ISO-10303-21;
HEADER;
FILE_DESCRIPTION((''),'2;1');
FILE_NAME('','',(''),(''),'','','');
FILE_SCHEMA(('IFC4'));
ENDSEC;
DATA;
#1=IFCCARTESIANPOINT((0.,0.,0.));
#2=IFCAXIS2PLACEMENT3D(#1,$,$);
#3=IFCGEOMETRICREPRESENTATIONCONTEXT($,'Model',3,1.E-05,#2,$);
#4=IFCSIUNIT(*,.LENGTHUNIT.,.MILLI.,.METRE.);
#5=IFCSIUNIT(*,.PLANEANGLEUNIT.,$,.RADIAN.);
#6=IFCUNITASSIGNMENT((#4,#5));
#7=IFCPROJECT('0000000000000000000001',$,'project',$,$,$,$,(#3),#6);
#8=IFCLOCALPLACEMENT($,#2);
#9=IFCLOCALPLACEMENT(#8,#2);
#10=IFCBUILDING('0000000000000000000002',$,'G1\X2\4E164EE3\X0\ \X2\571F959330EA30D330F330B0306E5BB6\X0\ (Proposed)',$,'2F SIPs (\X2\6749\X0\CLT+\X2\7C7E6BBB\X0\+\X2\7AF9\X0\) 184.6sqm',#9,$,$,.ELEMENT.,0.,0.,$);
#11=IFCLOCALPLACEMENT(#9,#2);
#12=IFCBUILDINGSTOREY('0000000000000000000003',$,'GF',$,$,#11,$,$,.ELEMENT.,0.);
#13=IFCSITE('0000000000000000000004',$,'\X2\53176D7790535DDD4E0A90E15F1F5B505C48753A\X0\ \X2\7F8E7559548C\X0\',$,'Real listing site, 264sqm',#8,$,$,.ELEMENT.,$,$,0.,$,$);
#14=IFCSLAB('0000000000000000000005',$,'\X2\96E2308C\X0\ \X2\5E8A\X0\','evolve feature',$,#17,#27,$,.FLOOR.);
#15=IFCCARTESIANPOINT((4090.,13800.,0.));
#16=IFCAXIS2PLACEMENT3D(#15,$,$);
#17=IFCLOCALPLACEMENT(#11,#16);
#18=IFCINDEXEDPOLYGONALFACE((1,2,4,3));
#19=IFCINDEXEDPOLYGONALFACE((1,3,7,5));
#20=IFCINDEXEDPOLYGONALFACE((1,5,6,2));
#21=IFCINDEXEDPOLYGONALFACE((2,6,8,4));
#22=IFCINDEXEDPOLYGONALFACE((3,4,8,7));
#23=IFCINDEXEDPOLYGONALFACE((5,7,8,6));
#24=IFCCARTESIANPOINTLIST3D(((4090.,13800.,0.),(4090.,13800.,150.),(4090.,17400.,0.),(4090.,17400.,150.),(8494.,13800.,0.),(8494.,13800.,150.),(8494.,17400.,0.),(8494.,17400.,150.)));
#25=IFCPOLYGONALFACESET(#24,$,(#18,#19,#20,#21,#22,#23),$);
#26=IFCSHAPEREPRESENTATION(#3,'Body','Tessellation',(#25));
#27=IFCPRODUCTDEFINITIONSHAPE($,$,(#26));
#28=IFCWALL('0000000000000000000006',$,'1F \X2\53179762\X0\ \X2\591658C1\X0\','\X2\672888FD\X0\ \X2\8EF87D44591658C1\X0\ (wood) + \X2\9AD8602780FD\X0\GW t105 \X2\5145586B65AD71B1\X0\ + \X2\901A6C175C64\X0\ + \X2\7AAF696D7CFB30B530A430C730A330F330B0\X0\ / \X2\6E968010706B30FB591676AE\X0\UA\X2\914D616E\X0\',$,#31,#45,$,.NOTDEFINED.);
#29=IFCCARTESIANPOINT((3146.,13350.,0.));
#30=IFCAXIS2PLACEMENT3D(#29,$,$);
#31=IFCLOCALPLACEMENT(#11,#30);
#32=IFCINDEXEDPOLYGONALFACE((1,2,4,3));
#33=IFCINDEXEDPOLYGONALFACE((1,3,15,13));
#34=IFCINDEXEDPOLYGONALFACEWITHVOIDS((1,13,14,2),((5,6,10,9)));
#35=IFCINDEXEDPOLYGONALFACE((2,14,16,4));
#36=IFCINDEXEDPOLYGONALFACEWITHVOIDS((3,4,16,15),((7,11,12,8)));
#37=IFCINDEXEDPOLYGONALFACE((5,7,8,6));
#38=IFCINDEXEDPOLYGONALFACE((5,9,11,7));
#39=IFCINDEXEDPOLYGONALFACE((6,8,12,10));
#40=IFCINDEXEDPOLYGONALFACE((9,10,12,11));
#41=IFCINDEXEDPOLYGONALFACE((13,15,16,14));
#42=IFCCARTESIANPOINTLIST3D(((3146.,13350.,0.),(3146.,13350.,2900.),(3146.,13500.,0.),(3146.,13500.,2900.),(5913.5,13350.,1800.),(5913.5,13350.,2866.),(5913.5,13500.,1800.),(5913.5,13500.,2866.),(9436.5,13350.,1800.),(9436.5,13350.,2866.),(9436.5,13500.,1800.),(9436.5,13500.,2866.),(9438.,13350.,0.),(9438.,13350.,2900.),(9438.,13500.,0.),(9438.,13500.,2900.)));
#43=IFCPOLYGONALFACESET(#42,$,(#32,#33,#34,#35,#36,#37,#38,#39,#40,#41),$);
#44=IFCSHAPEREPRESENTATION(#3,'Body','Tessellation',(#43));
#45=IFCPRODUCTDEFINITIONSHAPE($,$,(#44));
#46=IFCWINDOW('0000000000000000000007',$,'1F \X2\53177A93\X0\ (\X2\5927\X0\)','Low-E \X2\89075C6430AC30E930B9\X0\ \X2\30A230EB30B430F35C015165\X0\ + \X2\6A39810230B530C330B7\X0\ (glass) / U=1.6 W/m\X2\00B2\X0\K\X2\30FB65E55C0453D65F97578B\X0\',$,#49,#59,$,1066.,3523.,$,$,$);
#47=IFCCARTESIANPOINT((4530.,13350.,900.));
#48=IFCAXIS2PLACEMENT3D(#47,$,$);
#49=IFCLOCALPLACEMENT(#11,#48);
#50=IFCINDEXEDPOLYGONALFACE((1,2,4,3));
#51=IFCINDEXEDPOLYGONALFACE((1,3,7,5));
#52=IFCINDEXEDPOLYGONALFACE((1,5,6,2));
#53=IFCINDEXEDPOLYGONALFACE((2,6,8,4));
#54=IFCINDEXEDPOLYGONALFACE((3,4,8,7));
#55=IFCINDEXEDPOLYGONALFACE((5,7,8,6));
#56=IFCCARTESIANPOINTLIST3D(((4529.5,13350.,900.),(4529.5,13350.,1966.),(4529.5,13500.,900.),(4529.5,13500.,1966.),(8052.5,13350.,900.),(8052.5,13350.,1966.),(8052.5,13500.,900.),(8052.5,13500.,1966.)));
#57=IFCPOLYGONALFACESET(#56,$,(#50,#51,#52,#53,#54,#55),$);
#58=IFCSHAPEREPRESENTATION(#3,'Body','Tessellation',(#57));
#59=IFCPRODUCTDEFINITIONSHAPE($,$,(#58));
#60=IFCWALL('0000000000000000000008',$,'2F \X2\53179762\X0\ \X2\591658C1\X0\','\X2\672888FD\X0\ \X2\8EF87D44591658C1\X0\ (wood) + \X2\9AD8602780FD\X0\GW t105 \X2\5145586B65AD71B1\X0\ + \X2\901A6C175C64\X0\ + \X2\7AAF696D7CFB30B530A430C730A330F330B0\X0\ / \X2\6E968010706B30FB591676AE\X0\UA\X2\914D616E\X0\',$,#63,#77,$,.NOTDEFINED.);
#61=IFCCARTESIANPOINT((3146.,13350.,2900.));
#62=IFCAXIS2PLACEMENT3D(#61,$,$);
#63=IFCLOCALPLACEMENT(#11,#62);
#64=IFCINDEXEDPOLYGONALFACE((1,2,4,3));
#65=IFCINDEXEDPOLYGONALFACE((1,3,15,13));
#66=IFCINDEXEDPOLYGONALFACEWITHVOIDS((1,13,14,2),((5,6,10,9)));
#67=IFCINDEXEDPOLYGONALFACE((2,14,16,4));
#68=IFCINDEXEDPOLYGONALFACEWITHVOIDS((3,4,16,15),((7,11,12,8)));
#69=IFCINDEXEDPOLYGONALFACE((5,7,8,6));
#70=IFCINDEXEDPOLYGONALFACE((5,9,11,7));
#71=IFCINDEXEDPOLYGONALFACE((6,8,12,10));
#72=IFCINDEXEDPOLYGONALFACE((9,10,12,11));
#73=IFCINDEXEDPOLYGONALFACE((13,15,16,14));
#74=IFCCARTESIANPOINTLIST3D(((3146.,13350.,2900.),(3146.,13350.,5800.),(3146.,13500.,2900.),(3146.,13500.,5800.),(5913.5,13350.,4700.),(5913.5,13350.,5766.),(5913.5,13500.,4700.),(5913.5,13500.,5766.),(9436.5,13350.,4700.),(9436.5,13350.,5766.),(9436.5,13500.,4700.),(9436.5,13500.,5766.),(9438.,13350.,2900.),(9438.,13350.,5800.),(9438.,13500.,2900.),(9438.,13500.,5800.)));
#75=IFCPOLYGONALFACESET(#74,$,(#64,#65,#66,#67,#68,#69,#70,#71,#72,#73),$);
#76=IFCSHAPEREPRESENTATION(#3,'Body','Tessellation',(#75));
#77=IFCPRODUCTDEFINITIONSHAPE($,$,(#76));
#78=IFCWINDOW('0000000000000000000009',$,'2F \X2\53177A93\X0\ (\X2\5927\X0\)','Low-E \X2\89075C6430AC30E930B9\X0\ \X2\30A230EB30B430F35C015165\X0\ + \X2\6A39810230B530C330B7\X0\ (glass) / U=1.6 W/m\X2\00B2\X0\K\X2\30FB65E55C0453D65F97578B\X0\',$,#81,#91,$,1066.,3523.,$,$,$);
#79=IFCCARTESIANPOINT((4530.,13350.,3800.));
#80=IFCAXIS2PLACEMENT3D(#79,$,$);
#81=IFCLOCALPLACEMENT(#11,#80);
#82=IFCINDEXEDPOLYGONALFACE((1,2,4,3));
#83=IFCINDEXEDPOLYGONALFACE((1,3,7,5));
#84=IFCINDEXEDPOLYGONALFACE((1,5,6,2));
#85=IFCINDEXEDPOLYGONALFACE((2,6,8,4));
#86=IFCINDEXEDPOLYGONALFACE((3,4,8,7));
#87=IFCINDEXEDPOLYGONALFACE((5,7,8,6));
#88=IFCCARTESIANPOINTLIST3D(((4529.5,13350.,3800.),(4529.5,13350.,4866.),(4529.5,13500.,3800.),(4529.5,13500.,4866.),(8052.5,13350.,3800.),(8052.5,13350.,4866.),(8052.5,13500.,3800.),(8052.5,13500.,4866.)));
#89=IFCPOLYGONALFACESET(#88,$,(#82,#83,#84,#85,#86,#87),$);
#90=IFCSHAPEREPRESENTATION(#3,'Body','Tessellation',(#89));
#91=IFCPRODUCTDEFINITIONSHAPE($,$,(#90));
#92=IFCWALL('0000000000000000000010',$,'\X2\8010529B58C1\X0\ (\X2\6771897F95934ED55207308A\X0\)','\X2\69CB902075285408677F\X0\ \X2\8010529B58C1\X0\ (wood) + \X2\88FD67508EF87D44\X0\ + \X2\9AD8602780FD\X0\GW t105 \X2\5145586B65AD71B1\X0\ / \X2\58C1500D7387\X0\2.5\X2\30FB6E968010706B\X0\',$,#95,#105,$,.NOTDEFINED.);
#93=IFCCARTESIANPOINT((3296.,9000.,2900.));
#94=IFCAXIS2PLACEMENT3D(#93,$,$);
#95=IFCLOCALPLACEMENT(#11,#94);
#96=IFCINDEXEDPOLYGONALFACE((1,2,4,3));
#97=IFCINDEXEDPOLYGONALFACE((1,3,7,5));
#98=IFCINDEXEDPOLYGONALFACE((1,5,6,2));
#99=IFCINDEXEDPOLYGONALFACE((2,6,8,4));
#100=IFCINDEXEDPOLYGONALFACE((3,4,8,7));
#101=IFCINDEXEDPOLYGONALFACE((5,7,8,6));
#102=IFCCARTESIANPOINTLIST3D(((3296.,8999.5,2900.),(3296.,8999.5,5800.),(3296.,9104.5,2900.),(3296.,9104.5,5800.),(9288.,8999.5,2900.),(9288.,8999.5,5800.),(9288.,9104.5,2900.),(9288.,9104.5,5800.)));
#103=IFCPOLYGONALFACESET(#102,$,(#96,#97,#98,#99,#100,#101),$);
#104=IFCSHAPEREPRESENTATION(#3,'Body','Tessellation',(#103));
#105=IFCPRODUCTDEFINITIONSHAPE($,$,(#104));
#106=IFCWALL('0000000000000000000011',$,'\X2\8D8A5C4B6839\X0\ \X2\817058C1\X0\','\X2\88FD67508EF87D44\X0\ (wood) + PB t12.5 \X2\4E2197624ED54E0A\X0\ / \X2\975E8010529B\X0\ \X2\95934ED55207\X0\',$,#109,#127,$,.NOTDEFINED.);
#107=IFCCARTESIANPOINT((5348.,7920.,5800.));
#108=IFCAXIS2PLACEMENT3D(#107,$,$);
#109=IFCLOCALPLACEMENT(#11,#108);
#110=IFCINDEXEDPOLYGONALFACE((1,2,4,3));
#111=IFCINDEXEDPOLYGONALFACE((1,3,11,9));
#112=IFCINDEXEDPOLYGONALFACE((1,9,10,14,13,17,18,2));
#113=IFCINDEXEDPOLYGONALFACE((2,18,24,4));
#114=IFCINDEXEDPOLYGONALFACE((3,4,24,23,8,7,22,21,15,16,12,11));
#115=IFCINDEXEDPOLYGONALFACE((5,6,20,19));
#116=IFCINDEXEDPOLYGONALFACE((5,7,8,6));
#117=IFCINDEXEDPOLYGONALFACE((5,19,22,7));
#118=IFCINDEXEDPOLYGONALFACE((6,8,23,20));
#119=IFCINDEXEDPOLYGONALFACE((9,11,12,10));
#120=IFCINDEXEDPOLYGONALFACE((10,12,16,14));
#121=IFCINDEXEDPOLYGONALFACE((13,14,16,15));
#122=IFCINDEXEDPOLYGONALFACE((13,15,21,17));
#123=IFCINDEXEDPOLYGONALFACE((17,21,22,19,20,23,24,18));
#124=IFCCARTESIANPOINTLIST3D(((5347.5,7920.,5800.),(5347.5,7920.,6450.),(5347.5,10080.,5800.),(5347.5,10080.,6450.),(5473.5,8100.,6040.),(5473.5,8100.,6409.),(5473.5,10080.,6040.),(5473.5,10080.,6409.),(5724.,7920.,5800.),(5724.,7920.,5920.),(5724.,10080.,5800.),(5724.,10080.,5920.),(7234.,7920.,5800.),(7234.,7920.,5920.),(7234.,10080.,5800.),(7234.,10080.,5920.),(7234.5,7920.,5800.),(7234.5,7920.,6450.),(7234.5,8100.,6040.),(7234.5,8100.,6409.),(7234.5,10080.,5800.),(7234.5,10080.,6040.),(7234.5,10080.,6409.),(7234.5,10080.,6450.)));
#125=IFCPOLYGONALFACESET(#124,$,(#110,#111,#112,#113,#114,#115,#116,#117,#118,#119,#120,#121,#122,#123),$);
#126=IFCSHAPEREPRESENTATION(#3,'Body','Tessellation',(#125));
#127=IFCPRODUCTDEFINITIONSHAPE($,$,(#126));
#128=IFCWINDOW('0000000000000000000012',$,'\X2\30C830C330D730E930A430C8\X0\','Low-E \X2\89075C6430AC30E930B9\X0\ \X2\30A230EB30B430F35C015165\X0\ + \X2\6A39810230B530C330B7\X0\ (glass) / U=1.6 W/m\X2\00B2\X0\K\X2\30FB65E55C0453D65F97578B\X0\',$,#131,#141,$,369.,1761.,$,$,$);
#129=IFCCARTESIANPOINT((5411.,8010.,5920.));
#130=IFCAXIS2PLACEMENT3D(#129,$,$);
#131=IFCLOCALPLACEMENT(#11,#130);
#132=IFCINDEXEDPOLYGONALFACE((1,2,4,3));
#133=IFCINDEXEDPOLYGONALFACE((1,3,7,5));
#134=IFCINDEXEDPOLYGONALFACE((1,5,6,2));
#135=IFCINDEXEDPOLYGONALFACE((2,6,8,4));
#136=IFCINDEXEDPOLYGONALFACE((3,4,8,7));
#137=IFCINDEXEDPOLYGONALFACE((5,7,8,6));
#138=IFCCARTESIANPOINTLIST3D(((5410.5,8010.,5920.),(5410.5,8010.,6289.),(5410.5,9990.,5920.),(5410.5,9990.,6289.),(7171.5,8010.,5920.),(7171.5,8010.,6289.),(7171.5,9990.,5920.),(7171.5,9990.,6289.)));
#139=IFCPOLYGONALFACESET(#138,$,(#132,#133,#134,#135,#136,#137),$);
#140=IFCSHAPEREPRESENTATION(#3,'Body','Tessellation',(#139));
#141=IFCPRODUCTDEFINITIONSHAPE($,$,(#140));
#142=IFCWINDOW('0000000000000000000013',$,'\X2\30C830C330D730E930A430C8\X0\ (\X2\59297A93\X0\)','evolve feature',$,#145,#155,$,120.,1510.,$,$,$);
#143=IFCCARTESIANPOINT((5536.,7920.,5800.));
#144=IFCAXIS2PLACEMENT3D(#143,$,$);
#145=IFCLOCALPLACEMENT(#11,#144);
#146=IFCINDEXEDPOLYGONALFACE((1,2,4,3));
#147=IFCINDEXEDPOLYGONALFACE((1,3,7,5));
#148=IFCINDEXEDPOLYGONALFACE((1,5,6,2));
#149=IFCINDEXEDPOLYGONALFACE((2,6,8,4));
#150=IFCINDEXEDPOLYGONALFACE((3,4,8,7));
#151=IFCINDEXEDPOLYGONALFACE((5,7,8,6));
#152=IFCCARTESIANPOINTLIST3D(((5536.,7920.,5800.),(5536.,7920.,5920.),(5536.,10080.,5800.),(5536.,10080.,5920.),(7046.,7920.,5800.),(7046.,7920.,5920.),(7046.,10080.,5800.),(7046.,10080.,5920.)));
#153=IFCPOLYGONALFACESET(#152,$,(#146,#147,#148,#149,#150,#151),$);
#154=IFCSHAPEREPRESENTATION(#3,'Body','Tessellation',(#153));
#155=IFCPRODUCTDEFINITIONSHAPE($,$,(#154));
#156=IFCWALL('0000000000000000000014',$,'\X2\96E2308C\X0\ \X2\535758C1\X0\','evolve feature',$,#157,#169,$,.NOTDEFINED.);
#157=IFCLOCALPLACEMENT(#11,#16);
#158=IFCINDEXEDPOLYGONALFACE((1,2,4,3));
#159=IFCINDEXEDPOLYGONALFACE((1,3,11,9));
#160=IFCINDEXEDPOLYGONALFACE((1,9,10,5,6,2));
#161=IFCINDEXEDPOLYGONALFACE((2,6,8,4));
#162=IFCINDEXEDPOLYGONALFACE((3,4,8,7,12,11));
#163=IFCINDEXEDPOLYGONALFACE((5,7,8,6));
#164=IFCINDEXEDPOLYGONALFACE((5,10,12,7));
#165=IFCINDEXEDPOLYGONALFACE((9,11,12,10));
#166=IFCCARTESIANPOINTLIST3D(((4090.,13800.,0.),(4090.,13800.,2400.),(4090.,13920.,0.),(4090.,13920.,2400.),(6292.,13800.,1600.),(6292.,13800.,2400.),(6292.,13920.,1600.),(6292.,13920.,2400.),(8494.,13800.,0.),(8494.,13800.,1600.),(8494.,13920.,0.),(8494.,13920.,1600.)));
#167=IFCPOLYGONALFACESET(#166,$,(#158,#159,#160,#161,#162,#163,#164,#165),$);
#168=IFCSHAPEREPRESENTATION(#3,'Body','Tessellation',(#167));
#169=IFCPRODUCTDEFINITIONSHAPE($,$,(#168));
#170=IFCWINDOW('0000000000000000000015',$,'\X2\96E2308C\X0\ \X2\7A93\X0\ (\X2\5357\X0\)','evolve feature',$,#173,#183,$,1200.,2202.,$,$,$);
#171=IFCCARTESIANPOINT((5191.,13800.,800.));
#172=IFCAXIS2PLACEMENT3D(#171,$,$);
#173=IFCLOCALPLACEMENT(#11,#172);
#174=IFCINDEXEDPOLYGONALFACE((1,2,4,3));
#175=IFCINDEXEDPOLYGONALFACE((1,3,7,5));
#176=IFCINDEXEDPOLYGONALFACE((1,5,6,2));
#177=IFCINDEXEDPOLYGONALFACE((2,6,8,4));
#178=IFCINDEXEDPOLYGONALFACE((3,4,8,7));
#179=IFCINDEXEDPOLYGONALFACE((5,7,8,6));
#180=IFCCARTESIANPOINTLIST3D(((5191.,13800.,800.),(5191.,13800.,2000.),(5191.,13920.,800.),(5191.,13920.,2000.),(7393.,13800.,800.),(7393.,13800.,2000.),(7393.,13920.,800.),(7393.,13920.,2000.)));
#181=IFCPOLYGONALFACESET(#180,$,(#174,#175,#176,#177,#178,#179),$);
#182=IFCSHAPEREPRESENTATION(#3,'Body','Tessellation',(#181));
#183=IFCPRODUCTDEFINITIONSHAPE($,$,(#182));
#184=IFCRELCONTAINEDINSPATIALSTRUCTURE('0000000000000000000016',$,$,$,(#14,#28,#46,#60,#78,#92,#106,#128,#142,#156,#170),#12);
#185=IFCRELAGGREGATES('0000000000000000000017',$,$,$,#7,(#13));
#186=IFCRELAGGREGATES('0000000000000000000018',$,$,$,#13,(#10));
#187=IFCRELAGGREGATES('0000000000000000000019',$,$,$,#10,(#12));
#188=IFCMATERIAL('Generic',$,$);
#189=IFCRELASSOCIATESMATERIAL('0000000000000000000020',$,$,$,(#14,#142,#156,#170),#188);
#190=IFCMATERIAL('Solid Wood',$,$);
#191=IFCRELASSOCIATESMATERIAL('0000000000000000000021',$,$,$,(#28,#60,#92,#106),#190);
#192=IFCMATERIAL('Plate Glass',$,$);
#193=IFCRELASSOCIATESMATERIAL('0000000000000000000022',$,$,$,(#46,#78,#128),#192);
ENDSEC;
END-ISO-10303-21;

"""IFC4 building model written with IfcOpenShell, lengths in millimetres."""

from ifc_helpers import new_model, si_unit, frame, frame_2d, origin, place, context, project, spatial, rectangle, extrude, material, element, fill, save


model = new_model("IFC4")

# Units and contexts
model_context = context("Model", 3, precision=1e-05, world=origin())
ifc_project = project(units=[si_unit("LENGTHUNIT", "METRE", prefix="MILLI"), si_unit("PLANEANGLEUNIT", "RADIAN")], contexts=[model_context])

# Site, building, storey
site_placement = place(None, origin())
site = spatial("IfcSite", under=ifc_project, at=site_placement, Name="北海道川上郡弟子屈町 美留和", ObjectType="Real listing site, 264sqm", CompositionType="ELEMENT", RefElevation=0.0)
building_placement = place(site_placement, origin())
building = spatial("IfcBuilding", under=site, at=building_placement, Name="G1世代 土間リビングの家 (Proposed)", ObjectType="2F SIPs (杉CLT+籾殻+竹) 184.6sqm", CompositionType="ELEMENT", ElevationOfRefHeight=0.0, ElevationOfTerrain=0.0)
storey_placement = place(building_placement, origin())
storey = spatial("IfcBuildingStorey", under=building, at=storey_placement, Name="GF", CompositionType="ELEMENT", Elevation=0.0)

# Slab
ifc_material_1 = material(Name="Generic")
slab_placement = place(storey_placement, frame((4090.0, 13800.0, 0.0)))
element("IfcSlab", 1, at=slab_placement, inside=storey, material=ifc_material_1, Name="離れ 床", Description="evolve feature", PredefinedType="FLOOR", context=model_context, shape_type="SweptSolid", body=[
    extrude(rectangle(XDim=4404.0, YDim=3600.0, at=frame_2d((2202.0, 1800.0))), frame((4090.0, 13800.0, 0.0)), (0.0, 0.0, 1.0), 150.0),
])

# Wall, opening, window
ifc_material_2 = material(Name="Solid Wood")
wall_1_placement = place(storey_placement, frame((3146.0, 13350.0, 0.0)))
wall_1 = element("IfcWall", 2, at=wall_1_placement, inside=storey, material=ifc_material_2, Name="1F 北面 外壁", Description="木製 軸組外壁 (wood) + 高性能GW t105 充填断熱 + 通気層 + 窯業系サイディング / 準耐火・外皮UA配慮", PredefinedType="NOTDEFINED", context=model_context, shape_type="SweptSolid", body=[
    extrude(rectangle(XDim=6292.0, YDim=150.0, at=frame_2d((3146.0, 75.0))), frame((3146.0, 13350.0, 0.0)), (0.0, 0.0, 1.0), 2900.0),
])
opening_1_placement = place(storey_placement, frame((4530.0, 13350.0, 900.0)))
opening_1 = element("IfcOpeningElement", 3, at=opening_1_placement, cuts=wall_1, PredefinedType="NOTDEFINED", context=model_context, shape_type="SweptSolid", body=[
    extrude(rectangle(XDim=3523.0, YDim=150.0, at=frame_2d((1761.0, 75.0))), frame((4530.0, 13350.0, 900.0)), (0.0, 0.0, 1.0), 1066.0),
])
ifc_material_3 = material(Name="Plate Glass")
window_1_placement = place(storey_placement, frame((4530.0, 13350.0, 900.0)))
window_1 = element("IfcWindow", 4, at=window_1_placement, inside=storey, material=ifc_material_3, Name="1F 北窓 (大)", Description="Low-E 複層ガラス アルゴン封入 + 樹脂サッシ (glass) / U=1.6 W/m²K・日射取得型", OverallHeight=1066.0, OverallWidth=3523.0, context=model_context, shape_type="SweptSolid", body=[
    extrude(rectangle(XDim=3523.0, YDim=150.0, at=frame_2d((1761.0, 75.0))), frame((4530.0, 13350.0, 900.0)), (0.0, 0.0, 1.0), 1066.0),
])
fill(opening_1, window_1)

# Wall, opening, window
wall_2_placement = place(storey_placement, frame((3146.0, 13350.0, 2900.0)))
wall_2 = element("IfcWall", 5, at=wall_2_placement, inside=storey, material=ifc_material_2, Name="2F 北面 外壁", Description="木製 軸組外壁 (wood) + 高性能GW t105 充填断熱 + 通気層 + 窯業系サイディング / 準耐火・外皮UA配慮", PredefinedType="NOTDEFINED", context=model_context, shape_type="SweptSolid", body=[
    extrude(rectangle(XDim=6292.0, YDim=150.0, at=frame_2d((3146.0, 75.0))), frame((3146.0, 13350.0, 2900.0)), (0.0, 0.0, 1.0), 2900.0),
])
opening_2_placement = place(storey_placement, frame((4530.0, 13350.0, 3800.0)))
opening_2 = element("IfcOpeningElement", 6, at=opening_2_placement, cuts=wall_2, PredefinedType="NOTDEFINED", context=model_context, shape_type="SweptSolid", body=[
    extrude(rectangle(XDim=3523.0, YDim=150.0, at=frame_2d((1761.0, 75.0))), frame((4530.0, 13350.0, 3800.0)), (0.0, 0.0, 1.0), 1066.0),
])
window_2_placement = place(storey_placement, frame((4530.0, 13350.0, 3800.0)))
window_2 = element("IfcWindow", 7, at=window_2_placement, inside=storey, material=ifc_material_3, Name="2F 北窓 (大)", Description="Low-E 複層ガラス アルゴン封入 + 樹脂サッシ (glass) / U=1.6 W/m²K・日射取得型", OverallHeight=1066.0, OverallWidth=3523.0, context=model_context, shape_type="SweptSolid", body=[
    extrude(rectangle(XDim=3523.0, YDim=150.0, at=frame_2d((1761.0, 75.0))), frame((4530.0, 13350.0, 3800.0)), (0.0, 0.0, 1.0), 1066.0),
])
fill(opening_2, window_2)

# Wall
wall_3_placement = place(storey_placement, frame((3296.0, 9000.0, 2900.0)))
element("IfcWall", 8, at=wall_3_placement, inside=storey, material=ifc_material_2, Name="耐力壁 (東西間仕切り)", Description="構造用合板 耐力壁 (wood) + 製材軸組 + 高性能GW t105 充填断熱 / 壁倍率2.5・準耐火", PredefinedType="NOTDEFINED", context=model_context, shape_type="SweptSolid", body=[
    extrude(rectangle(XDim=5992.0, YDim=105.0, at=frame_2d((2996.0, 52.0))), frame((3296.0, 9000.0, 2900.0)), (0.0, 0.0, 1.0), 2900.0),
])

# Wall, openings, windows
wall_4_placement = place(storey_placement, frame((5348.0, 7920.0, 5800.0)))
wall_4 = element("IfcWall", 9, at=wall_4_placement, inside=storey, material=ifc_material_2, Name="越屋根 腰壁", Description="製材軸組 (wood) + PB t12.5 両面仕上 / 非耐力 間仕切", PredefinedType="NOTDEFINED", context=model_context, shape_type="SweptSolid", body=[
    extrude(rectangle(XDim=1887.0, YDim=2160.0, at=frame_2d((943.0, 1080.0))), frame((5348.0, 7920.0, 5800.0)), (0.0, 0.0, 1.0), 650.0),
])
opening_3_placement = place(storey_placement, frame((5411.0, 8010.0, 5920.0)))
opening_3 = element("IfcOpeningElement", 10, at=opening_3_placement, cuts=wall_4, PredefinedType="NOTDEFINED", context=model_context, shape_type="SweptSolid", body=[
    extrude(rectangle(XDim=1761.0, YDim=1980.0, at=frame_2d((880.0, 990.0))), frame((5411.0, 8010.0, 5920.0)), (0.0, 0.0, 1.0), 369.0),
])
opening_4_placement = place(storey_placement, frame((5536.0, 7920.0, 5800.0)))
opening_4 = element("IfcOpeningElement", 11, at=opening_4_placement, cuts=wall_4, PredefinedType="NOTDEFINED", context=model_context, shape_type="SweptSolid", body=[
    extrude(rectangle(XDim=1510.0, YDim=2160.0, at=frame_2d((755.0, 1080.0))), frame((5536.0, 7920.0, 5800.0)), (0.0, 0.0, 1.0), 120.0),
])
window_3_placement = place(storey_placement, frame((5411.0, 8010.0, 5920.0)))
window_3 = element("IfcWindow", 12, at=window_3_placement, inside=storey, material=ifc_material_3, Name="トップライト", Description="Low-E 複層ガラス アルゴン封入 + 樹脂サッシ (glass) / U=1.6 W/m²K・日射取得型", OverallHeight=369.0, OverallWidth=1761.0, context=model_context, shape_type="SweptSolid", body=[
    extrude(rectangle(XDim=1761.0, YDim=1980.0, at=frame_2d((880.0, 990.0))), frame((5411.0, 8010.0, 5920.0)), (0.0, 0.0, 1.0), 369.0),
])
fill(opening_3, window_3)
window_4_placement = place(storey_placement, frame((5536.0, 7920.0, 5800.0)))
window_4 = element("IfcWindow", 13, at=window_4_placement, inside=storey, material=ifc_material_1, Name="トップライト (天窓)", Description="evolve feature", OverallHeight=120.0, OverallWidth=1510.0, context=model_context, shape_type="SweptSolid", body=[
    extrude(rectangle(XDim=1510.0, YDim=2160.0, at=frame_2d((755.0, 1080.0))), frame((5536.0, 7920.0, 5800.0)), (0.0, 0.0, 1.0), 120.0),
])
fill(opening_4, window_4)

# Wall, opening, window
wall_5_placement = place(storey_placement, frame((4090.0, 13800.0, 0.0)))
wall_5 = element("IfcWall", 14, at=wall_5_placement, inside=storey, material=ifc_material_1, Name="離れ 南壁", Description="evolve feature", PredefinedType="NOTDEFINED", context=model_context, shape_type="SweptSolid", body=[
    extrude(rectangle(XDim=4404.0, YDim=120.0, at=frame_2d((2202.0, 60.0))), frame((4090.0, 13800.0, 0.0)), (0.0, 0.0, 1.0), 2400.0),
])
opening_5_placement = place(storey_placement, frame((5191.0, 13800.0, 800.0)))
opening_5 = element("IfcOpeningElement", 15, at=opening_5_placement, cuts=wall_5, PredefinedType="NOTDEFINED", context=model_context, shape_type="SweptSolid", body=[
    extrude(rectangle(XDim=2202.0, YDim=120.0, at=frame_2d((1101.0, 60.0))), frame((5191.0, 13800.0, 800.0)), (0.0, 0.0, 1.0), 1200.0),
])
window_5_placement = place(storey_placement, frame((5191.0, 13800.0, 800.0)))
window_5 = element("IfcWindow", 16, at=window_5_placement, inside=storey, material=ifc_material_1, Name="離れ 窓 (南)", Description="evolve feature", OverallHeight=1200.0, OverallWidth=2202.0, context=model_context, shape_type="SweptSolid", body=[
    extrude(rectangle(XDim=2202.0, YDim=120.0, at=frame_2d((1101.0, 60.0))), frame((5191.0, 13800.0, 800.0)), (0.0, 0.0, 1.0), 1200.0),
])
fill(opening_5, window_5)

save(model, "model.ifc")
